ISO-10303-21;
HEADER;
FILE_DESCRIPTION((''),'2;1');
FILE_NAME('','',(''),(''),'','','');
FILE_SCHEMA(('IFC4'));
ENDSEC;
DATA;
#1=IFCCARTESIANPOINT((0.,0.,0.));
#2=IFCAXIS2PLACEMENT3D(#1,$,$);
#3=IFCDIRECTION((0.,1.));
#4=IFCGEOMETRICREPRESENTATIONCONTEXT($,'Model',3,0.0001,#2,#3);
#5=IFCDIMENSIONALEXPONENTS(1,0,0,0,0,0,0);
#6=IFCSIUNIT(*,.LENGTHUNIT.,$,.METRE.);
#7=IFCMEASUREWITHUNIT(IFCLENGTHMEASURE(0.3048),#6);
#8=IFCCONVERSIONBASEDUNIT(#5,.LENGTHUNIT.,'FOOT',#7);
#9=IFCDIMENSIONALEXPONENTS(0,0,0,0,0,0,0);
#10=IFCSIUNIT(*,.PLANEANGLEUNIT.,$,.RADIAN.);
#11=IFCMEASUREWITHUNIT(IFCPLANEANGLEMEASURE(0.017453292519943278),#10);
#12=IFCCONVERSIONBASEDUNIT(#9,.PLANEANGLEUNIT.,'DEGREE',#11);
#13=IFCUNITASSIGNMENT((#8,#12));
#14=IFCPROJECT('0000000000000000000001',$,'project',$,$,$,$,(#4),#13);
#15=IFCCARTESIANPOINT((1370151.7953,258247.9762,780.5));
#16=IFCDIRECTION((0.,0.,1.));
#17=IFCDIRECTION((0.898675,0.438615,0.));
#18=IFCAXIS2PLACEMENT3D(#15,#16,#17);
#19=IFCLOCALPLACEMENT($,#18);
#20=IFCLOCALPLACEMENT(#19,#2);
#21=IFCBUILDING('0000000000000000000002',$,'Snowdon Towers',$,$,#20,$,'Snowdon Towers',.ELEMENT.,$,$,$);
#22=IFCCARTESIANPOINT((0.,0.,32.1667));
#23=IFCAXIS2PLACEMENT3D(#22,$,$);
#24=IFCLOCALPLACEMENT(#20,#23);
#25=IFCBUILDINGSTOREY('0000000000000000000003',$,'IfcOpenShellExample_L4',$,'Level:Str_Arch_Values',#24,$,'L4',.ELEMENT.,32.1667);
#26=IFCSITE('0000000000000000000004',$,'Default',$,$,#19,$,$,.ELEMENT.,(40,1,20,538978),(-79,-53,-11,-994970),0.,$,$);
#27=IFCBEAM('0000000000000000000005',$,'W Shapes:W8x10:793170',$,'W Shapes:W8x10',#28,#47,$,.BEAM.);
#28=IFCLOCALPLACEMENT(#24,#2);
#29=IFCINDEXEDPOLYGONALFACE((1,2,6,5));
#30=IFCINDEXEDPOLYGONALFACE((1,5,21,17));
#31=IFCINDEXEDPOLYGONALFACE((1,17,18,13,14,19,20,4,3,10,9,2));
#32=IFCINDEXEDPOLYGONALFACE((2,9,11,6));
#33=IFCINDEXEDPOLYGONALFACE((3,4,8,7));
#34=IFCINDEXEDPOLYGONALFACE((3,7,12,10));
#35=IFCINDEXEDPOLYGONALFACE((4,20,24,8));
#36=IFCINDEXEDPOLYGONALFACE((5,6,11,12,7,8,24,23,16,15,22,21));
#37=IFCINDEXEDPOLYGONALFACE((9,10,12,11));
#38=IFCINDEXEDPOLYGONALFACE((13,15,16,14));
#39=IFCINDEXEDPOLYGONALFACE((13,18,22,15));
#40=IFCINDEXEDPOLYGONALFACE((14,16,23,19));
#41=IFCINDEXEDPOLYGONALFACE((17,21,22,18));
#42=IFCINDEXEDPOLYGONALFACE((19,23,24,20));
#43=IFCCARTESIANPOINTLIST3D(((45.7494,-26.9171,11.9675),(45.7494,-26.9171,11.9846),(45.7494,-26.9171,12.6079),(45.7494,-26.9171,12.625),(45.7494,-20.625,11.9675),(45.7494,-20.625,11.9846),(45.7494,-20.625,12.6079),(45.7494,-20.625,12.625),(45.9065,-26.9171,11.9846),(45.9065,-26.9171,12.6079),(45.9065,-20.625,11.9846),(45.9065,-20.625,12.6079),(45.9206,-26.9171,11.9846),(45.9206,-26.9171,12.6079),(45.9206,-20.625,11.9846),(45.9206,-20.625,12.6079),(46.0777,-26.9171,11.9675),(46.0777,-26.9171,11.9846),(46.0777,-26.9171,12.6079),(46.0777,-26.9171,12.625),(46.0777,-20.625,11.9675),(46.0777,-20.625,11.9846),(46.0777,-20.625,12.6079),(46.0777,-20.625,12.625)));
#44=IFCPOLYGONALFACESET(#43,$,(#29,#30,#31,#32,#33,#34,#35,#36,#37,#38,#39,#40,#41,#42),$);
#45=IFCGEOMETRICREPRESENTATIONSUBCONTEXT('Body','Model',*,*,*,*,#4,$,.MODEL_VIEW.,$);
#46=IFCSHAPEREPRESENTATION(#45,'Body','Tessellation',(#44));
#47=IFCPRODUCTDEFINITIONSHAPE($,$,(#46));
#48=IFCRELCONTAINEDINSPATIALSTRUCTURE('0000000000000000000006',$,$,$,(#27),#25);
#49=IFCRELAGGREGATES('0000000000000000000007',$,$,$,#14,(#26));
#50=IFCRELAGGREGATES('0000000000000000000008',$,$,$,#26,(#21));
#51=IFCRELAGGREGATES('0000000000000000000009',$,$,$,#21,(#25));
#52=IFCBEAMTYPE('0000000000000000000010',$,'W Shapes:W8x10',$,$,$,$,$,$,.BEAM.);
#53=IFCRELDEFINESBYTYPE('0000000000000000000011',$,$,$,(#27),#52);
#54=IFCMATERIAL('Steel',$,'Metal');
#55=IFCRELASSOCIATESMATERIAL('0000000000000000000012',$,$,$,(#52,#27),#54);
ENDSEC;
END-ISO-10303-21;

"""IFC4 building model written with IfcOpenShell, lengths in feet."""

from ifc_helpers import new_model, entity, si_unit, converted_unit, direction, frame, origin, place, context, subcontext, project, spatial, indexed_curve, outline, extrude, source, transform, mapped, material, type_object, type_shapes, element, save


model = new_model("IFC4")

# Units and contexts
model_context = context("Model", 3, precision=0.0001, world=origin(), true_north=direction((0.0, 1.0)))
body_context = subcontext(model_context, "Body", "Model", "MODEL_VIEW")
ifc_project = project(units=[converted_unit("LENGTHUNIT", "FOOT", entity("IfcLengthMeasure", 0.3048), si_unit("LENGTHUNIT", "METRE"), dimensions=[1, 0, 0, 0, 0, 0, 0]), converted_unit("PLANEANGLEUNIT", "DEGREE", entity("IfcPlaneAngleMeasure", 0.017453292519943278), si_unit("PLANEANGLEUNIT", "RADIAN"), dimensions=[0, 0, 0, 0, 0, 0, 0])], contexts=[model_context])

# Site, building, storey
site_placement = place(None, frame((1370151.7953, 258247.9762, 780.5), z_axis=(0.0, 0.0, 1.0), x_axis=(0.898675, 0.438615, 0.0)))
site = spatial("IfcSite", under=ifc_project, at=site_placement, Name="Default", CompositionType="ELEMENT", RefLatitude=(40, 1, 20, 538978), RefLongitude=(-79, -53, -11, -994970), RefElevation=0.0)
building_placement = place(site_placement, origin())
building = spatial("IfcBuilding", under=site, at=building_placement, Name="Snowdon Towers", LongName="Snowdon Towers", CompositionType="ELEMENT")
storey_placement = place(building_placement, frame((0.0, 0.0, 32.1667)))
storey = spatial("IfcBuildingStorey", under=building, at=storey_placement, Name="IfcOpenShellExample_L4", ObjectType="Level:Str_Arch_Values", LongName="L4", CompositionType="ELEMENT", Elevation=32.1667)

# Shared definitions
ifc_material = material(Name="Steel", Category="Metal")

# Beam
beam_type_1 = type_object("IfcBeamType", Name="W Shapes:W8x10", PredefinedType="BEAM", material=ifc_material)
shared_shape_1 = source(origin(), body_context, "Body", "SweptSolid", [
    extrude(outline(indexed_curve([(-0.1642, -0.3117), (-0.1642, -0.3288), (0.1642, -0.3288), (0.1642, -0.3117), (0.0071, -0.3117), (0.0071, 0.3117), (0.1642, 0.3117), (0.1642, 0.3287), (-0.1642, 0.3287), (-0.1642, 0.3117), (-0.0071, 0.3117), (-0.0071, -0.3117), (-0.1642, -0.3117)], self_intersect=False)), frame((-3.0585, 0.0, 0.0), z_axis=(-1.0, 0.0, 0.0), x_axis=(0.0, -1.0, 0.0)), (0.0, 0.0, -1.0), 6.2921),
])
type_shapes(beam_type_1, [shared_shape_1])
beam_1_placement = place(storey_placement, frame((45.9135, -23.6835, 12.2963), z_axis=(0.0, 0.0, 1.0), x_axis=(0.0, -1.0, 0.0)))
element("IfcBeam", 1, at=beam_1_placement, inside=storey, type_object=beam_type_1, material=ifc_material, Name="W Shapes:W8x10:793170", ObjectType="W Shapes:W8x10", PredefinedType="BEAM", context=body_context, shape_type="MappedRepresentation", body=[
    mapped(shared_shape_1, transform((0.0, 0.0, 0.0), scale=1.0)),
])

save(model, "model.ifc")
